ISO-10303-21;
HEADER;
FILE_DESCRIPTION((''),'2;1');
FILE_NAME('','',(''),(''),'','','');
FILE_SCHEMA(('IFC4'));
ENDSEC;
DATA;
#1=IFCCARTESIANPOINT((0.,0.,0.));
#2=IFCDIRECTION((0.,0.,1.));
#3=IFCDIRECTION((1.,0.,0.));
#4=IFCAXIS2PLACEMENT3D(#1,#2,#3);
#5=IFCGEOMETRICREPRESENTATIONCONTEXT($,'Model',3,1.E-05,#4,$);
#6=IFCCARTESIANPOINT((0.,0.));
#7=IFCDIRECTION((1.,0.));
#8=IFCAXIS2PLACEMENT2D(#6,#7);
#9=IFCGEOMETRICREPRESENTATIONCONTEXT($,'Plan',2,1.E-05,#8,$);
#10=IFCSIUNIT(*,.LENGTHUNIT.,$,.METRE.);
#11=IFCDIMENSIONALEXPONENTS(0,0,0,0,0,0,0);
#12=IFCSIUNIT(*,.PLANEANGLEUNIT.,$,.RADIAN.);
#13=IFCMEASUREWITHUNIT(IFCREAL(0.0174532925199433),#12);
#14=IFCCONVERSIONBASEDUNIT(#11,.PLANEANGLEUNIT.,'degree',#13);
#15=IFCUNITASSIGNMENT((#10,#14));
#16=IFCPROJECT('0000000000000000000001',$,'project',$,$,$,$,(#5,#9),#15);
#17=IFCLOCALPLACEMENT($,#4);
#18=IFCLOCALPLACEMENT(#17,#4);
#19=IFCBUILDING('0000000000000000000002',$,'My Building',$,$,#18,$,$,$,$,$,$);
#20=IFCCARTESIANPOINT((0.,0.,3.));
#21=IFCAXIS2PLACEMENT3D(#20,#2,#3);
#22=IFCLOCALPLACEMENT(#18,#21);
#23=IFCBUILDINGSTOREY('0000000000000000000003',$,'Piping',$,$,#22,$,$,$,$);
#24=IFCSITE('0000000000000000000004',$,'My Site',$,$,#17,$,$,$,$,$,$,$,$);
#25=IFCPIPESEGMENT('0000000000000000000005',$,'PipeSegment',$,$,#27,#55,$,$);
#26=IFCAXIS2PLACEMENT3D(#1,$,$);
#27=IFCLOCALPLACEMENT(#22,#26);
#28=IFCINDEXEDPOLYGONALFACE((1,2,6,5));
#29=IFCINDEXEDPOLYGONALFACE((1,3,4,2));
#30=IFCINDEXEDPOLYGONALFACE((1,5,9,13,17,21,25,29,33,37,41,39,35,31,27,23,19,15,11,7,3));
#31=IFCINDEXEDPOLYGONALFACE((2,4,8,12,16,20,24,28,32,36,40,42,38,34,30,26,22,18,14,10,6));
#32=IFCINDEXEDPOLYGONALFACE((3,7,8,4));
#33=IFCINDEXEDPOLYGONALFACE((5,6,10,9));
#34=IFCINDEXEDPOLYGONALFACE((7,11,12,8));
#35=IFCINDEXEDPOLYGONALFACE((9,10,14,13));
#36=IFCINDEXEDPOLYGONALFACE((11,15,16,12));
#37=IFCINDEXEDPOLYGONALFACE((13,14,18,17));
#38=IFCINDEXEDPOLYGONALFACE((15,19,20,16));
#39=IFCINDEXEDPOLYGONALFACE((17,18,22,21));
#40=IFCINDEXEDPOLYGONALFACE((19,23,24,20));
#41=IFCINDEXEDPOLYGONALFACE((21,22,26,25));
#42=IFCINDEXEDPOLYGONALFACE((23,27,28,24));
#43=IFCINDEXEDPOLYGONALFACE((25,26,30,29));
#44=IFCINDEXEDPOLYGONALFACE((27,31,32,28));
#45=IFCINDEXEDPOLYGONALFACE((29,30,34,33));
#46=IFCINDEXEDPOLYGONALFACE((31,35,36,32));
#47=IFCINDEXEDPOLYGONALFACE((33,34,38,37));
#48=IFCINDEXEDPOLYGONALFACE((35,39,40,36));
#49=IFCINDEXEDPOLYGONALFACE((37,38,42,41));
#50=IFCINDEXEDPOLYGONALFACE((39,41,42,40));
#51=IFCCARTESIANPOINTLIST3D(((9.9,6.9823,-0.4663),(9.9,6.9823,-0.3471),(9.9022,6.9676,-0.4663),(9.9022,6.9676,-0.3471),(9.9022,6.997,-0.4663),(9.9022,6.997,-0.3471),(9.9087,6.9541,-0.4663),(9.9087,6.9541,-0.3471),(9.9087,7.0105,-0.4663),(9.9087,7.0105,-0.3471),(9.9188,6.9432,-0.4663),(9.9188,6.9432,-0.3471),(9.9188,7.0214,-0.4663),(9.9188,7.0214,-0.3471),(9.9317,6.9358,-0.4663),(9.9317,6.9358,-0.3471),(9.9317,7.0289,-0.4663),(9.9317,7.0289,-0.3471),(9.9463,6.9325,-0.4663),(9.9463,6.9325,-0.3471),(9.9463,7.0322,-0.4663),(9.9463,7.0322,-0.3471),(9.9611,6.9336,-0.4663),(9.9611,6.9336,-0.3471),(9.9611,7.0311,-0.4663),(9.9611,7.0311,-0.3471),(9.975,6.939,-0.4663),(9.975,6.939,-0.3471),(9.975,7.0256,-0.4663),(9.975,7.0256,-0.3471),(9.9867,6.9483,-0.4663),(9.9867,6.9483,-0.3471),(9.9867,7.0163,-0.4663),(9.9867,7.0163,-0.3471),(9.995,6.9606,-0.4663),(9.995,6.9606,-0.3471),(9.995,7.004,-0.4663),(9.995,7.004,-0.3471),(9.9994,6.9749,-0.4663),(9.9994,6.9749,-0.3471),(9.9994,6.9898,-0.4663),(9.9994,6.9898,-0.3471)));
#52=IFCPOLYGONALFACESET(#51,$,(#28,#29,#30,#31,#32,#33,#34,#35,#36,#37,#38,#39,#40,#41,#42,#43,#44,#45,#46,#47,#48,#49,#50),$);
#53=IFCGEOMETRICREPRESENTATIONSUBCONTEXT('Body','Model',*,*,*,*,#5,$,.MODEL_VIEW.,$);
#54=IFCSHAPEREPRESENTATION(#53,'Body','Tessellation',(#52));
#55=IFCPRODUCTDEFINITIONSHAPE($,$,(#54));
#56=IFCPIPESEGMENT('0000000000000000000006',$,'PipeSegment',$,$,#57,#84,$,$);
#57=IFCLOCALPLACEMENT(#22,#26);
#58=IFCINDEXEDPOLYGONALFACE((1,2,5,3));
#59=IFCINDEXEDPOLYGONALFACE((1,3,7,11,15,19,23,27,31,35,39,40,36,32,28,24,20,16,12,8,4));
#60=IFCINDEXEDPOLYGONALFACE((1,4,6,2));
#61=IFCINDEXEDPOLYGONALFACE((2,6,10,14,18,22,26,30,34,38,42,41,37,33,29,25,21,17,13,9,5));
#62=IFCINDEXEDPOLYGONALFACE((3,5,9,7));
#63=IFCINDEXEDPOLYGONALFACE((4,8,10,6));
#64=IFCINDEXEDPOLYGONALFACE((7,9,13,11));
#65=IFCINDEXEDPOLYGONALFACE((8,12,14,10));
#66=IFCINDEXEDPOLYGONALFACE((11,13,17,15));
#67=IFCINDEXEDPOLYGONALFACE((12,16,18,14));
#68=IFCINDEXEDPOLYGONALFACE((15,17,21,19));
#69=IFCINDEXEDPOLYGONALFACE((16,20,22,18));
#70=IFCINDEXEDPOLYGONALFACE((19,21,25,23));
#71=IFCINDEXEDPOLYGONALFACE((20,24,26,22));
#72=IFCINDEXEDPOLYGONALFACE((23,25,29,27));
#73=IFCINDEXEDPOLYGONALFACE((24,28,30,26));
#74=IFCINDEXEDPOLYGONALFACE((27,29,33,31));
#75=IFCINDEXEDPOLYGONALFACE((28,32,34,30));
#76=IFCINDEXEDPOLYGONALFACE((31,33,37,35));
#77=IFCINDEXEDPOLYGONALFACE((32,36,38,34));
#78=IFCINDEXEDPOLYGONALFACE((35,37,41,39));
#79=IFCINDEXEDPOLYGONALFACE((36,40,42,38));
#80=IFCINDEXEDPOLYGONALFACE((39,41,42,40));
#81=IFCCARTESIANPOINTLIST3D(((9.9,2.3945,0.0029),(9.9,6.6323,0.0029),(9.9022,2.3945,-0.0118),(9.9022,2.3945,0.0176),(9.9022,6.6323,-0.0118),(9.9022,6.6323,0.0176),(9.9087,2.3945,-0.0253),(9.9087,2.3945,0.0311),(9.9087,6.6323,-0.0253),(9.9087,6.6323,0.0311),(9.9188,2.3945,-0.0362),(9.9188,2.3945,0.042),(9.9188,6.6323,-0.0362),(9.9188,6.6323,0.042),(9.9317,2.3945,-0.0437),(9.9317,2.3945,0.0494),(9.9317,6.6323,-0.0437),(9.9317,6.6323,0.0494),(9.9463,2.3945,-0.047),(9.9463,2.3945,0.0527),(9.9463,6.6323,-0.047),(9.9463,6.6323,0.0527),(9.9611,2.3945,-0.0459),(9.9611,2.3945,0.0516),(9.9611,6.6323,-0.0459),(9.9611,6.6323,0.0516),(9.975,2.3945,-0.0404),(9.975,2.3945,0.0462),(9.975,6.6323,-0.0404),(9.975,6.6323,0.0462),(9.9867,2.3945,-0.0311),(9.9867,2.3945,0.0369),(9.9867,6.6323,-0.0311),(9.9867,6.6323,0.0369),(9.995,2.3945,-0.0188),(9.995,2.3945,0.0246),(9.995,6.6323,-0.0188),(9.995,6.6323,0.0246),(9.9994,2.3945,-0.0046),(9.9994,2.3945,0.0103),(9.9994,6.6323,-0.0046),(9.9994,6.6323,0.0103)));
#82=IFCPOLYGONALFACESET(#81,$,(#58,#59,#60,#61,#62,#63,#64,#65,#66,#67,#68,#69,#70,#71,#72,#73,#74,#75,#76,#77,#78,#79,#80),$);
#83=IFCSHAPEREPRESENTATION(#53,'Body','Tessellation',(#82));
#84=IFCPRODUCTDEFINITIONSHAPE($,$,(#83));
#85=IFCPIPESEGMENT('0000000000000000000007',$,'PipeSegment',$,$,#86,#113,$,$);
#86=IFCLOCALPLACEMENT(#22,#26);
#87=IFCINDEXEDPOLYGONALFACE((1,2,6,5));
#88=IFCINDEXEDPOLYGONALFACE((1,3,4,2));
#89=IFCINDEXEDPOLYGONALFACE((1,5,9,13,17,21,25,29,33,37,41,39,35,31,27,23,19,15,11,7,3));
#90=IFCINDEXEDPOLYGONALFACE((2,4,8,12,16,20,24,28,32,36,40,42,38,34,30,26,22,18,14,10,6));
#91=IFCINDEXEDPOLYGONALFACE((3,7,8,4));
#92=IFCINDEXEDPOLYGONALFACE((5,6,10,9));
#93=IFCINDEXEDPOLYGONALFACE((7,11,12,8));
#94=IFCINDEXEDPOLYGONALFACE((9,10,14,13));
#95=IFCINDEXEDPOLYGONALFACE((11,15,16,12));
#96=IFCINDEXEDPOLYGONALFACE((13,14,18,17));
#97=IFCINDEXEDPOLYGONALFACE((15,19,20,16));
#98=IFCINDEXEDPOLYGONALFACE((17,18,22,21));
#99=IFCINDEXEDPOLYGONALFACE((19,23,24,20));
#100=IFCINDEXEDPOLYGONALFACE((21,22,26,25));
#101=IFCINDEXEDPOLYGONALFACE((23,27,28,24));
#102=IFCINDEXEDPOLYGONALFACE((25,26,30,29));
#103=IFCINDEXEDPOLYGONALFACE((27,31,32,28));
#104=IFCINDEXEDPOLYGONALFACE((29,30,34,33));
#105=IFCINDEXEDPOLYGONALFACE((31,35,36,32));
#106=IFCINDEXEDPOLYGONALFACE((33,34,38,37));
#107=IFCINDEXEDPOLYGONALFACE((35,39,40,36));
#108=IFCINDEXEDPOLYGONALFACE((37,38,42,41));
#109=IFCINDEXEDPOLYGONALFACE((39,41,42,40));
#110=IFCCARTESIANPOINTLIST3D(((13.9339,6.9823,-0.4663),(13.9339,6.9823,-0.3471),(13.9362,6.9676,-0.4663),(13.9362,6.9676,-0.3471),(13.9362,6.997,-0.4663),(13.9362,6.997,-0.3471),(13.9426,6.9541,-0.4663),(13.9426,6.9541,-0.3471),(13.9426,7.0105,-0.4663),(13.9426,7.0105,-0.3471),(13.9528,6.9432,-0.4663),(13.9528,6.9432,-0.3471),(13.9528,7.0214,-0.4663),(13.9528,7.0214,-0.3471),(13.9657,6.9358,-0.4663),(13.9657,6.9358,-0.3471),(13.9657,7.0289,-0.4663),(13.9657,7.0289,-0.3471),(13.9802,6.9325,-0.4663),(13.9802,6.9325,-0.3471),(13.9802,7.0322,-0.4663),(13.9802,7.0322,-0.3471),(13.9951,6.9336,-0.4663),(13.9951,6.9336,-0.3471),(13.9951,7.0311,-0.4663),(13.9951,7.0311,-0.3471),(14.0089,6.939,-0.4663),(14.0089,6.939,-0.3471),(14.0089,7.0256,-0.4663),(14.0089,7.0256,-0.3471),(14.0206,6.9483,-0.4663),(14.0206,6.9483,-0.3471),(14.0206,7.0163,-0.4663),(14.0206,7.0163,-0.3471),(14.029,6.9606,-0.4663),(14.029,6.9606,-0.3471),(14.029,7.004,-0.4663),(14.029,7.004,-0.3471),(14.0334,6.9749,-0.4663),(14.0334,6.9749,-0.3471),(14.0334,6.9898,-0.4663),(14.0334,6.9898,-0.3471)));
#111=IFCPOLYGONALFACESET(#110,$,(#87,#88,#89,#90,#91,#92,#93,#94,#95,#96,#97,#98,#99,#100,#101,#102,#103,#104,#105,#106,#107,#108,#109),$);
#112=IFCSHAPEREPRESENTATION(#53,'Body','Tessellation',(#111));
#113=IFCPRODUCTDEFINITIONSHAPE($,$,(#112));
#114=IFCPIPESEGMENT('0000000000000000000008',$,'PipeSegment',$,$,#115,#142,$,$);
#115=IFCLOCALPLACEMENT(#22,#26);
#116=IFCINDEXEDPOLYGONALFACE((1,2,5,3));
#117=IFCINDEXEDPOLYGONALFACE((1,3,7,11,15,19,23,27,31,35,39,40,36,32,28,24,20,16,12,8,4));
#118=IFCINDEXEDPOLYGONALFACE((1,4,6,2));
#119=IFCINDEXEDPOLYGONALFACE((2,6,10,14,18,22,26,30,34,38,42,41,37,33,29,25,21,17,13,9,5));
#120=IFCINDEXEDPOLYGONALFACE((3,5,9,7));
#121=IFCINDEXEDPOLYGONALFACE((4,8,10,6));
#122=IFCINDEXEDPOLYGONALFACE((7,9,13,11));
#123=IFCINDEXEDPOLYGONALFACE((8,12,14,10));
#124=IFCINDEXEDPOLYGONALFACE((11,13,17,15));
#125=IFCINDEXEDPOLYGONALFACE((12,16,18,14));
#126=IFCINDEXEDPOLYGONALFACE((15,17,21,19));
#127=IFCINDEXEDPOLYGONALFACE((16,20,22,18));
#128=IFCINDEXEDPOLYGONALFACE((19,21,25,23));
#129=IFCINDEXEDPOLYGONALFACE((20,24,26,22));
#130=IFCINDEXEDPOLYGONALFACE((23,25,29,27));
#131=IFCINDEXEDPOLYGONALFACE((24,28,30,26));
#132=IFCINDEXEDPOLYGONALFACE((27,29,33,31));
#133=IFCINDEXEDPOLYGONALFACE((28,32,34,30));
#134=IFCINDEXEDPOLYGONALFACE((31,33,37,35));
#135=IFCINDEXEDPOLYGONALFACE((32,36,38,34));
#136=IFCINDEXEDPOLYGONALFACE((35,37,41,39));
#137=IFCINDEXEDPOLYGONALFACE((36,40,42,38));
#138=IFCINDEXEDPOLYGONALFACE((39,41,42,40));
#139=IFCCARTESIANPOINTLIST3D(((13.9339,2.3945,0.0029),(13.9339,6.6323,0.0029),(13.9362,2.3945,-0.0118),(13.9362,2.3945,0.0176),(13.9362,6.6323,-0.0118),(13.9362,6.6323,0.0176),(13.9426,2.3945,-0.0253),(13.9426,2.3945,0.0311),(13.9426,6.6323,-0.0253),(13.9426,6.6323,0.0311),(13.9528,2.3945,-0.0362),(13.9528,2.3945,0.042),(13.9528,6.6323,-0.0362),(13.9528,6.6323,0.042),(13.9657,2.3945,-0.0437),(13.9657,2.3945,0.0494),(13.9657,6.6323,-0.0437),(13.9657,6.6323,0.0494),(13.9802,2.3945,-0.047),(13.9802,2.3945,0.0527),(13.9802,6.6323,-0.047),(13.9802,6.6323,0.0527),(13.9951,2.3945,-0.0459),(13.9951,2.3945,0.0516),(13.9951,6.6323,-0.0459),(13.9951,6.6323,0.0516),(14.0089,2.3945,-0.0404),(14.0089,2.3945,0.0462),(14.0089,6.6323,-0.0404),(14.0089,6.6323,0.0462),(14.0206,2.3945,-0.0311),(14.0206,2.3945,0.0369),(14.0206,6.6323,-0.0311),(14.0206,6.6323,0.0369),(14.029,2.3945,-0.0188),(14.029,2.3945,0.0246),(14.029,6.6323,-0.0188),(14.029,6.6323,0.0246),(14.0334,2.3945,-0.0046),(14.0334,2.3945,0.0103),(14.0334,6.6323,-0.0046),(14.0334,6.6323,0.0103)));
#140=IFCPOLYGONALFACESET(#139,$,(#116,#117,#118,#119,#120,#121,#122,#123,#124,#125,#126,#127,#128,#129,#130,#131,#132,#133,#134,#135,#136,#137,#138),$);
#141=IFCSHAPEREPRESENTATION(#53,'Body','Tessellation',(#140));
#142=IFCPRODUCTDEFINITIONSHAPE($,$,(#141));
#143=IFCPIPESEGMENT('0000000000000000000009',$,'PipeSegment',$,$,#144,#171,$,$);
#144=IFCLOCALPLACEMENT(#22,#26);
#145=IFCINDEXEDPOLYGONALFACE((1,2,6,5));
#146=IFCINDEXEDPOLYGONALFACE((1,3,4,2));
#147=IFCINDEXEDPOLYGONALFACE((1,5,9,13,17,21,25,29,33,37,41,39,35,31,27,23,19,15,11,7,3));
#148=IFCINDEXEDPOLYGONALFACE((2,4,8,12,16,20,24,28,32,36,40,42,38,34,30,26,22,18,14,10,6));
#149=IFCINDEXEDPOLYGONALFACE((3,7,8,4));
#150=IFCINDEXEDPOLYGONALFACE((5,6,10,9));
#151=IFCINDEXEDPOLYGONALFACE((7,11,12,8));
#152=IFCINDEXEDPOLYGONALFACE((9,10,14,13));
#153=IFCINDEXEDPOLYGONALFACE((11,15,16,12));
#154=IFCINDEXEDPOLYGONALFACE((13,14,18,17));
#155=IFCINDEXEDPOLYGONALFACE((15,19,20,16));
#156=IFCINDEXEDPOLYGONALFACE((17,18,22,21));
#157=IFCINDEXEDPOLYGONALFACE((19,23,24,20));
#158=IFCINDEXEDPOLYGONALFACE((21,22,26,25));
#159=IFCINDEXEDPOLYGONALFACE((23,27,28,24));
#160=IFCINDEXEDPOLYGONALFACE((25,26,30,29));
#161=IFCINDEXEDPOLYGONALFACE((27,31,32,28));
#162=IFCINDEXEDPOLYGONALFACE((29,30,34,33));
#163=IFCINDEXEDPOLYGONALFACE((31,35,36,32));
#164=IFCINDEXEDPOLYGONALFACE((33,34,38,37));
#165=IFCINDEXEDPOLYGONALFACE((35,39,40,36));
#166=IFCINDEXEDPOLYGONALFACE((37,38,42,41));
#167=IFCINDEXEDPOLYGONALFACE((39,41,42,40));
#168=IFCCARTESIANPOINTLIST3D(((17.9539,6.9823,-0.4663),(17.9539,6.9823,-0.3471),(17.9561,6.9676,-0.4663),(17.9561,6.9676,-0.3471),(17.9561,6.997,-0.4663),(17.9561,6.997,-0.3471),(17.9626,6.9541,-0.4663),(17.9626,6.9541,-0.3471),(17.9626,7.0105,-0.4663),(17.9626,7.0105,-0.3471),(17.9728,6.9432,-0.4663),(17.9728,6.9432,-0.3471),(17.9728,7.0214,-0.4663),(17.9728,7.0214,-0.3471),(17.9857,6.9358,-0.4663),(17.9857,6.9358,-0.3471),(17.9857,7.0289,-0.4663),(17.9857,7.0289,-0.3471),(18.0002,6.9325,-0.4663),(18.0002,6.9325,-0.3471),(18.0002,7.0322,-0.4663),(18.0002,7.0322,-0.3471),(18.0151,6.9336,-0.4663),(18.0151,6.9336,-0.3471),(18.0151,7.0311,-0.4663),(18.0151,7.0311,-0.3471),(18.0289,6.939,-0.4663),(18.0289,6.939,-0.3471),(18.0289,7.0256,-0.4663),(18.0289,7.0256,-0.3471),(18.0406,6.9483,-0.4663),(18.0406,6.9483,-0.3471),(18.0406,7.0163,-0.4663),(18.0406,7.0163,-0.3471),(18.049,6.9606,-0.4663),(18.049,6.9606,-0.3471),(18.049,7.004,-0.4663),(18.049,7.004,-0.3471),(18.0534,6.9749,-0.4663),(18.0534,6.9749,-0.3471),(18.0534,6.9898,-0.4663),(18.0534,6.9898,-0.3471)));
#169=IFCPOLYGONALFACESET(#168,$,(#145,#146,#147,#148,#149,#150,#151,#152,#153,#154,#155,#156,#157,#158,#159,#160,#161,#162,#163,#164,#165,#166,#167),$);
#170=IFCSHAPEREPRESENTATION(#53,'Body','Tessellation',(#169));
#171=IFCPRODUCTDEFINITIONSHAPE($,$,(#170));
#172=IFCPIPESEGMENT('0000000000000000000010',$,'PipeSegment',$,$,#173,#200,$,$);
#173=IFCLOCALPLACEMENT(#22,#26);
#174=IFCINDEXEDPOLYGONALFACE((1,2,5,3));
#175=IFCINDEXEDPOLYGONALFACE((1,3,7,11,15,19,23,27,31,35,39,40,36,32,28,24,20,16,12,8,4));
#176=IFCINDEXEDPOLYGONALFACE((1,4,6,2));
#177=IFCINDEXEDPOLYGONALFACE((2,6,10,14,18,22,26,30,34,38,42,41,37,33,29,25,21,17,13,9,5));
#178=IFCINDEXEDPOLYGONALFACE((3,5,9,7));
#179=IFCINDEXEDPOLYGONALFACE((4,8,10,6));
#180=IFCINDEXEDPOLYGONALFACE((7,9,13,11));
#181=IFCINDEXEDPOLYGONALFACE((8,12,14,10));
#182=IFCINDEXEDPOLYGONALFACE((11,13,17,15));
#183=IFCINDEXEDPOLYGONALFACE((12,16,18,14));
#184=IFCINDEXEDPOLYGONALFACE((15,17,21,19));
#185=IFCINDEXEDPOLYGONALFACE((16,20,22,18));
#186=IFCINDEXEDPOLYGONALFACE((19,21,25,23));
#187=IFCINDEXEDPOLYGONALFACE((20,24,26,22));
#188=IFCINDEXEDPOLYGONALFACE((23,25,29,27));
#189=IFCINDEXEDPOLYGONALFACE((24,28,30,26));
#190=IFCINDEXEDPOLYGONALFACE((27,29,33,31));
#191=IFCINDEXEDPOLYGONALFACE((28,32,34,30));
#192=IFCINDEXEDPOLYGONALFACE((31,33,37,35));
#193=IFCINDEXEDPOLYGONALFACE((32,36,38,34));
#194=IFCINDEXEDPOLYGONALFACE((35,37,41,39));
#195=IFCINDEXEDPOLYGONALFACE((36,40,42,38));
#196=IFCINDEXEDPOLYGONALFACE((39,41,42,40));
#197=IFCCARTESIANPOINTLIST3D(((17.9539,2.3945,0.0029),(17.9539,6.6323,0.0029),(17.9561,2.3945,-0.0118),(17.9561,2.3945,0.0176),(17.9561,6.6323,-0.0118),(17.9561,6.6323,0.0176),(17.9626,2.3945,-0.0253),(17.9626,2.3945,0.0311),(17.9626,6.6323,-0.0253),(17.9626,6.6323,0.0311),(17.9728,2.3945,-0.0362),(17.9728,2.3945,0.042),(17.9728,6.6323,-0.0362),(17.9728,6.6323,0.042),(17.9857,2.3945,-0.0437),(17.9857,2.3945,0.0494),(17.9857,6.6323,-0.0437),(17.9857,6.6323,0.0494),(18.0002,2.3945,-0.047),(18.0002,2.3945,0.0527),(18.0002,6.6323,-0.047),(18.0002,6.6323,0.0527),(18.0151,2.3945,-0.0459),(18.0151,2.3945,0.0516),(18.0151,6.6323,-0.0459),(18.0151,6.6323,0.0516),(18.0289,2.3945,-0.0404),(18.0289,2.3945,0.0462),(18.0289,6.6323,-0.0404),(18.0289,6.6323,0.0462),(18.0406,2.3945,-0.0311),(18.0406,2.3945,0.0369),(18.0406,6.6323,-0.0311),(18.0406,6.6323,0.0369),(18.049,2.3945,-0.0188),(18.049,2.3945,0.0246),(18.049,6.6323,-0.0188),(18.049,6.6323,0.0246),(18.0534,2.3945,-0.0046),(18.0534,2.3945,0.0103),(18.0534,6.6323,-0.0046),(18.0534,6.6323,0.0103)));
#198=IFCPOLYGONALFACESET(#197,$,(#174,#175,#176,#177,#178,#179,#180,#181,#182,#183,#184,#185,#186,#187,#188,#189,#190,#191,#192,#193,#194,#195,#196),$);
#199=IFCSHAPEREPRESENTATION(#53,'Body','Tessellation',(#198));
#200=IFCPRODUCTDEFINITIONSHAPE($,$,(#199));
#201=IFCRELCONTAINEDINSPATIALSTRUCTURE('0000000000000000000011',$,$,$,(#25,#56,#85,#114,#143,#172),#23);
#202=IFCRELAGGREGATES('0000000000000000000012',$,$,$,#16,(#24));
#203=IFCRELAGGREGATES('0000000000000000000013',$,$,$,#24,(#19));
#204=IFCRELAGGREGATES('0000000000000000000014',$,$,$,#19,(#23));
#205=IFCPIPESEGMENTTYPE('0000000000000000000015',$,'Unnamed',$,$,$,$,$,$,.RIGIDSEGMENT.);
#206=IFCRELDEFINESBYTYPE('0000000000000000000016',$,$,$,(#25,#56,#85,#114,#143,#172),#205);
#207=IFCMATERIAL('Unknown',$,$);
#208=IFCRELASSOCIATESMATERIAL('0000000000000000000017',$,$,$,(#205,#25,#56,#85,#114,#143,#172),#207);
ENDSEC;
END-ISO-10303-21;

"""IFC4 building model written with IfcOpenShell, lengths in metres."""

from ifc_helpers import new_model, entity, si_unit, converted_unit, frame, origin_with_axes, origin_2d_with_axis, place, context, subcontext, project, spatial, circle, extrude, material, material_profile, profile_set, profile_usage, type_object, element, save


model = new_model("IFC4")

# Units and contexts
model_context = context("Model", 3, precision=1e-05, world=origin_with_axes())
plan_context = context("Plan", 2, precision=1e-05, world=origin_2d_with_axis())
body_context = subcontext(model_context, "Body", "Model", "MODEL_VIEW")
ifc_project = project(units=[si_unit("LENGTHUNIT", "METRE"), converted_unit("PLANEANGLEUNIT", "degree", entity("IfcReal", 0.0174532925199433), si_unit("PLANEANGLEUNIT", "RADIAN"), dimensions=[0, 0, 0, 0, 0, 0, 0])], contexts=[model_context, plan_context])

# Site, building, storey
site_placement = place(None, origin_with_axes())
site = spatial("IfcSite", under=ifc_project, at=site_placement, Name="My Site")
building_placement = place(site_placement, origin_with_axes())
building = spatial("IfcBuilding", under=site, at=building_placement, Name="My Building")
storey_placement = place(building_placement, frame((0.0, 0.0, 3.0), z_axis=(0.0, 0.0, 1.0), x_axis=(1.0, 0.0, 0.0)))
storey = spatial("IfcBuildingStorey", under=building, at=storey_placement, Name="Piping")

# Pipe segments
ifc_material = material(Name="Unknown")
ifc_material_profile_1 = material_profile(ifc_material, circle(Radius=0.05))
ifc_profile_set_1 = profile_set([ifc_material_profile_1])
pipe_segment_type = type_object("IfcPipeSegmentType", Name="Unnamed", PredefinedType="RIGIDSEGMENT", material=ifc_profile_set_1)
ifc_profile_usage_1 = profile_usage(ifc_profile_set_1, cardinal=5)
pipe_segment_1_placement = place(storey_placement, frame((9.95, 6.9823, -0.3471), z_axis=(0.0, 0.0, -1.0), x_axis=(-1.0, 0.0, 0.0)))
element("IfcPipeSegment", 1, at=pipe_segment_1_placement, inside=storey, type_object=pipe_segment_type, material=ifc_profile_usage_1, Name="PipeSegment", context=body_context, shape_type="SweptSolid", body=[
    extrude(circle(Radius=0.05), origin_with_axes(), (0.0, 0.0, 1.0), 0.1192),
])
ifc_profile_usage_2 = profile_usage(ifc_profile_set_1, cardinal=5)
pipe_segment_2_placement = place(storey_placement, frame((9.95, 2.3945, 0.0029), z_axis=(0.0, 1.0, 0.0), x_axis=(-1.0, 0.0, 0.0)))
element("IfcPipeSegment", 2, at=pipe_segment_2_placement, inside=storey, type_object=pipe_segment_type, material=ifc_profile_usage_2, Name="PipeSegment", context=body_context, shape_type="SweptSolid", body=[
    extrude(circle(Radius=0.05), origin_with_axes(), (0.0, 0.0, 1.0), 4.2379),
])
ifc_profile_usage_3 = profile_usage(ifc_profile_set_1, cardinal=5)
pipe_segment_3_placement = place(storey_placement, frame((13.9839, 6.9823, -0.3471), z_axis=(0.0, 0.0, -1.0), x_axis=(-1.0, 0.0, 0.0)))
element("IfcPipeSegment", 3, at=pipe_segment_3_placement, inside=storey, type_object=pipe_segment_type, material=ifc_profile_usage_3, Name="PipeSegment", context=body_context, shape_type="SweptSolid", body=[
    extrude(circle(Radius=0.05), origin_with_axes(), (0.0, 0.0, 1.0), 0.1192),
])
ifc_profile_usage_4 = profile_usage(ifc_profile_set_1, cardinal=5)
pipe_segment_4_placement = place(storey_placement, frame((13.9839, 2.3945, 0.0029), z_axis=(0.0, 1.0, 0.0), x_axis=(-1.0, 0.0, 0.0)))
element("IfcPipeSegment", 4, at=pipe_segment_4_placement, inside=storey, type_object=pipe_segment_type, material=ifc_profile_usage_4, Name="PipeSegment", context=body_context, shape_type="SweptSolid", body=[
    extrude(circle(Radius=0.05), origin_with_axes(), (0.0, 0.0, 1.0), 4.2379),
])
ifc_profile_usage_5 = profile_usage(ifc_profile_set_1, cardinal=5)
pipe_segment_5_placement = place(storey_placement, frame((18.0039, 6.9823, -0.3471), z_axis=(0.0, 0.0, -1.0), x_axis=(-1.0, 0.0, 0.0)))
element("IfcPipeSegment", 5, at=pipe_segment_5_placement, inside=storey, type_object=pipe_segment_type, material=ifc_profile_usage_5, Name="PipeSegment", context=body_context, shape_type="SweptSolid", body=[
    extrude(circle(Radius=0.05), origin_with_axes(), (0.0, 0.0, 1.0), 0.1192),
])
ifc_profile_usage_6 = profile_usage(ifc_profile_set_1, cardinal=5)
pipe_segment_6_placement = place(storey_placement, frame((18.0039, 2.3945, 0.0029), z_axis=(0.0, 1.0, 0.0), x_axis=(-1.0, 0.0, 0.0)))
element("IfcPipeSegment", 6, at=pipe_segment_6_placement, inside=storey, type_object=pipe_segment_type, material=ifc_profile_usage_6, Name="PipeSegment", context=body_context, shape_type="SweptSolid", body=[
    extrude(circle(Radius=0.05), origin_with_axes(), (0.0, 0.0, 1.0), 4.2379),
])

save(model, "model.ifc")
